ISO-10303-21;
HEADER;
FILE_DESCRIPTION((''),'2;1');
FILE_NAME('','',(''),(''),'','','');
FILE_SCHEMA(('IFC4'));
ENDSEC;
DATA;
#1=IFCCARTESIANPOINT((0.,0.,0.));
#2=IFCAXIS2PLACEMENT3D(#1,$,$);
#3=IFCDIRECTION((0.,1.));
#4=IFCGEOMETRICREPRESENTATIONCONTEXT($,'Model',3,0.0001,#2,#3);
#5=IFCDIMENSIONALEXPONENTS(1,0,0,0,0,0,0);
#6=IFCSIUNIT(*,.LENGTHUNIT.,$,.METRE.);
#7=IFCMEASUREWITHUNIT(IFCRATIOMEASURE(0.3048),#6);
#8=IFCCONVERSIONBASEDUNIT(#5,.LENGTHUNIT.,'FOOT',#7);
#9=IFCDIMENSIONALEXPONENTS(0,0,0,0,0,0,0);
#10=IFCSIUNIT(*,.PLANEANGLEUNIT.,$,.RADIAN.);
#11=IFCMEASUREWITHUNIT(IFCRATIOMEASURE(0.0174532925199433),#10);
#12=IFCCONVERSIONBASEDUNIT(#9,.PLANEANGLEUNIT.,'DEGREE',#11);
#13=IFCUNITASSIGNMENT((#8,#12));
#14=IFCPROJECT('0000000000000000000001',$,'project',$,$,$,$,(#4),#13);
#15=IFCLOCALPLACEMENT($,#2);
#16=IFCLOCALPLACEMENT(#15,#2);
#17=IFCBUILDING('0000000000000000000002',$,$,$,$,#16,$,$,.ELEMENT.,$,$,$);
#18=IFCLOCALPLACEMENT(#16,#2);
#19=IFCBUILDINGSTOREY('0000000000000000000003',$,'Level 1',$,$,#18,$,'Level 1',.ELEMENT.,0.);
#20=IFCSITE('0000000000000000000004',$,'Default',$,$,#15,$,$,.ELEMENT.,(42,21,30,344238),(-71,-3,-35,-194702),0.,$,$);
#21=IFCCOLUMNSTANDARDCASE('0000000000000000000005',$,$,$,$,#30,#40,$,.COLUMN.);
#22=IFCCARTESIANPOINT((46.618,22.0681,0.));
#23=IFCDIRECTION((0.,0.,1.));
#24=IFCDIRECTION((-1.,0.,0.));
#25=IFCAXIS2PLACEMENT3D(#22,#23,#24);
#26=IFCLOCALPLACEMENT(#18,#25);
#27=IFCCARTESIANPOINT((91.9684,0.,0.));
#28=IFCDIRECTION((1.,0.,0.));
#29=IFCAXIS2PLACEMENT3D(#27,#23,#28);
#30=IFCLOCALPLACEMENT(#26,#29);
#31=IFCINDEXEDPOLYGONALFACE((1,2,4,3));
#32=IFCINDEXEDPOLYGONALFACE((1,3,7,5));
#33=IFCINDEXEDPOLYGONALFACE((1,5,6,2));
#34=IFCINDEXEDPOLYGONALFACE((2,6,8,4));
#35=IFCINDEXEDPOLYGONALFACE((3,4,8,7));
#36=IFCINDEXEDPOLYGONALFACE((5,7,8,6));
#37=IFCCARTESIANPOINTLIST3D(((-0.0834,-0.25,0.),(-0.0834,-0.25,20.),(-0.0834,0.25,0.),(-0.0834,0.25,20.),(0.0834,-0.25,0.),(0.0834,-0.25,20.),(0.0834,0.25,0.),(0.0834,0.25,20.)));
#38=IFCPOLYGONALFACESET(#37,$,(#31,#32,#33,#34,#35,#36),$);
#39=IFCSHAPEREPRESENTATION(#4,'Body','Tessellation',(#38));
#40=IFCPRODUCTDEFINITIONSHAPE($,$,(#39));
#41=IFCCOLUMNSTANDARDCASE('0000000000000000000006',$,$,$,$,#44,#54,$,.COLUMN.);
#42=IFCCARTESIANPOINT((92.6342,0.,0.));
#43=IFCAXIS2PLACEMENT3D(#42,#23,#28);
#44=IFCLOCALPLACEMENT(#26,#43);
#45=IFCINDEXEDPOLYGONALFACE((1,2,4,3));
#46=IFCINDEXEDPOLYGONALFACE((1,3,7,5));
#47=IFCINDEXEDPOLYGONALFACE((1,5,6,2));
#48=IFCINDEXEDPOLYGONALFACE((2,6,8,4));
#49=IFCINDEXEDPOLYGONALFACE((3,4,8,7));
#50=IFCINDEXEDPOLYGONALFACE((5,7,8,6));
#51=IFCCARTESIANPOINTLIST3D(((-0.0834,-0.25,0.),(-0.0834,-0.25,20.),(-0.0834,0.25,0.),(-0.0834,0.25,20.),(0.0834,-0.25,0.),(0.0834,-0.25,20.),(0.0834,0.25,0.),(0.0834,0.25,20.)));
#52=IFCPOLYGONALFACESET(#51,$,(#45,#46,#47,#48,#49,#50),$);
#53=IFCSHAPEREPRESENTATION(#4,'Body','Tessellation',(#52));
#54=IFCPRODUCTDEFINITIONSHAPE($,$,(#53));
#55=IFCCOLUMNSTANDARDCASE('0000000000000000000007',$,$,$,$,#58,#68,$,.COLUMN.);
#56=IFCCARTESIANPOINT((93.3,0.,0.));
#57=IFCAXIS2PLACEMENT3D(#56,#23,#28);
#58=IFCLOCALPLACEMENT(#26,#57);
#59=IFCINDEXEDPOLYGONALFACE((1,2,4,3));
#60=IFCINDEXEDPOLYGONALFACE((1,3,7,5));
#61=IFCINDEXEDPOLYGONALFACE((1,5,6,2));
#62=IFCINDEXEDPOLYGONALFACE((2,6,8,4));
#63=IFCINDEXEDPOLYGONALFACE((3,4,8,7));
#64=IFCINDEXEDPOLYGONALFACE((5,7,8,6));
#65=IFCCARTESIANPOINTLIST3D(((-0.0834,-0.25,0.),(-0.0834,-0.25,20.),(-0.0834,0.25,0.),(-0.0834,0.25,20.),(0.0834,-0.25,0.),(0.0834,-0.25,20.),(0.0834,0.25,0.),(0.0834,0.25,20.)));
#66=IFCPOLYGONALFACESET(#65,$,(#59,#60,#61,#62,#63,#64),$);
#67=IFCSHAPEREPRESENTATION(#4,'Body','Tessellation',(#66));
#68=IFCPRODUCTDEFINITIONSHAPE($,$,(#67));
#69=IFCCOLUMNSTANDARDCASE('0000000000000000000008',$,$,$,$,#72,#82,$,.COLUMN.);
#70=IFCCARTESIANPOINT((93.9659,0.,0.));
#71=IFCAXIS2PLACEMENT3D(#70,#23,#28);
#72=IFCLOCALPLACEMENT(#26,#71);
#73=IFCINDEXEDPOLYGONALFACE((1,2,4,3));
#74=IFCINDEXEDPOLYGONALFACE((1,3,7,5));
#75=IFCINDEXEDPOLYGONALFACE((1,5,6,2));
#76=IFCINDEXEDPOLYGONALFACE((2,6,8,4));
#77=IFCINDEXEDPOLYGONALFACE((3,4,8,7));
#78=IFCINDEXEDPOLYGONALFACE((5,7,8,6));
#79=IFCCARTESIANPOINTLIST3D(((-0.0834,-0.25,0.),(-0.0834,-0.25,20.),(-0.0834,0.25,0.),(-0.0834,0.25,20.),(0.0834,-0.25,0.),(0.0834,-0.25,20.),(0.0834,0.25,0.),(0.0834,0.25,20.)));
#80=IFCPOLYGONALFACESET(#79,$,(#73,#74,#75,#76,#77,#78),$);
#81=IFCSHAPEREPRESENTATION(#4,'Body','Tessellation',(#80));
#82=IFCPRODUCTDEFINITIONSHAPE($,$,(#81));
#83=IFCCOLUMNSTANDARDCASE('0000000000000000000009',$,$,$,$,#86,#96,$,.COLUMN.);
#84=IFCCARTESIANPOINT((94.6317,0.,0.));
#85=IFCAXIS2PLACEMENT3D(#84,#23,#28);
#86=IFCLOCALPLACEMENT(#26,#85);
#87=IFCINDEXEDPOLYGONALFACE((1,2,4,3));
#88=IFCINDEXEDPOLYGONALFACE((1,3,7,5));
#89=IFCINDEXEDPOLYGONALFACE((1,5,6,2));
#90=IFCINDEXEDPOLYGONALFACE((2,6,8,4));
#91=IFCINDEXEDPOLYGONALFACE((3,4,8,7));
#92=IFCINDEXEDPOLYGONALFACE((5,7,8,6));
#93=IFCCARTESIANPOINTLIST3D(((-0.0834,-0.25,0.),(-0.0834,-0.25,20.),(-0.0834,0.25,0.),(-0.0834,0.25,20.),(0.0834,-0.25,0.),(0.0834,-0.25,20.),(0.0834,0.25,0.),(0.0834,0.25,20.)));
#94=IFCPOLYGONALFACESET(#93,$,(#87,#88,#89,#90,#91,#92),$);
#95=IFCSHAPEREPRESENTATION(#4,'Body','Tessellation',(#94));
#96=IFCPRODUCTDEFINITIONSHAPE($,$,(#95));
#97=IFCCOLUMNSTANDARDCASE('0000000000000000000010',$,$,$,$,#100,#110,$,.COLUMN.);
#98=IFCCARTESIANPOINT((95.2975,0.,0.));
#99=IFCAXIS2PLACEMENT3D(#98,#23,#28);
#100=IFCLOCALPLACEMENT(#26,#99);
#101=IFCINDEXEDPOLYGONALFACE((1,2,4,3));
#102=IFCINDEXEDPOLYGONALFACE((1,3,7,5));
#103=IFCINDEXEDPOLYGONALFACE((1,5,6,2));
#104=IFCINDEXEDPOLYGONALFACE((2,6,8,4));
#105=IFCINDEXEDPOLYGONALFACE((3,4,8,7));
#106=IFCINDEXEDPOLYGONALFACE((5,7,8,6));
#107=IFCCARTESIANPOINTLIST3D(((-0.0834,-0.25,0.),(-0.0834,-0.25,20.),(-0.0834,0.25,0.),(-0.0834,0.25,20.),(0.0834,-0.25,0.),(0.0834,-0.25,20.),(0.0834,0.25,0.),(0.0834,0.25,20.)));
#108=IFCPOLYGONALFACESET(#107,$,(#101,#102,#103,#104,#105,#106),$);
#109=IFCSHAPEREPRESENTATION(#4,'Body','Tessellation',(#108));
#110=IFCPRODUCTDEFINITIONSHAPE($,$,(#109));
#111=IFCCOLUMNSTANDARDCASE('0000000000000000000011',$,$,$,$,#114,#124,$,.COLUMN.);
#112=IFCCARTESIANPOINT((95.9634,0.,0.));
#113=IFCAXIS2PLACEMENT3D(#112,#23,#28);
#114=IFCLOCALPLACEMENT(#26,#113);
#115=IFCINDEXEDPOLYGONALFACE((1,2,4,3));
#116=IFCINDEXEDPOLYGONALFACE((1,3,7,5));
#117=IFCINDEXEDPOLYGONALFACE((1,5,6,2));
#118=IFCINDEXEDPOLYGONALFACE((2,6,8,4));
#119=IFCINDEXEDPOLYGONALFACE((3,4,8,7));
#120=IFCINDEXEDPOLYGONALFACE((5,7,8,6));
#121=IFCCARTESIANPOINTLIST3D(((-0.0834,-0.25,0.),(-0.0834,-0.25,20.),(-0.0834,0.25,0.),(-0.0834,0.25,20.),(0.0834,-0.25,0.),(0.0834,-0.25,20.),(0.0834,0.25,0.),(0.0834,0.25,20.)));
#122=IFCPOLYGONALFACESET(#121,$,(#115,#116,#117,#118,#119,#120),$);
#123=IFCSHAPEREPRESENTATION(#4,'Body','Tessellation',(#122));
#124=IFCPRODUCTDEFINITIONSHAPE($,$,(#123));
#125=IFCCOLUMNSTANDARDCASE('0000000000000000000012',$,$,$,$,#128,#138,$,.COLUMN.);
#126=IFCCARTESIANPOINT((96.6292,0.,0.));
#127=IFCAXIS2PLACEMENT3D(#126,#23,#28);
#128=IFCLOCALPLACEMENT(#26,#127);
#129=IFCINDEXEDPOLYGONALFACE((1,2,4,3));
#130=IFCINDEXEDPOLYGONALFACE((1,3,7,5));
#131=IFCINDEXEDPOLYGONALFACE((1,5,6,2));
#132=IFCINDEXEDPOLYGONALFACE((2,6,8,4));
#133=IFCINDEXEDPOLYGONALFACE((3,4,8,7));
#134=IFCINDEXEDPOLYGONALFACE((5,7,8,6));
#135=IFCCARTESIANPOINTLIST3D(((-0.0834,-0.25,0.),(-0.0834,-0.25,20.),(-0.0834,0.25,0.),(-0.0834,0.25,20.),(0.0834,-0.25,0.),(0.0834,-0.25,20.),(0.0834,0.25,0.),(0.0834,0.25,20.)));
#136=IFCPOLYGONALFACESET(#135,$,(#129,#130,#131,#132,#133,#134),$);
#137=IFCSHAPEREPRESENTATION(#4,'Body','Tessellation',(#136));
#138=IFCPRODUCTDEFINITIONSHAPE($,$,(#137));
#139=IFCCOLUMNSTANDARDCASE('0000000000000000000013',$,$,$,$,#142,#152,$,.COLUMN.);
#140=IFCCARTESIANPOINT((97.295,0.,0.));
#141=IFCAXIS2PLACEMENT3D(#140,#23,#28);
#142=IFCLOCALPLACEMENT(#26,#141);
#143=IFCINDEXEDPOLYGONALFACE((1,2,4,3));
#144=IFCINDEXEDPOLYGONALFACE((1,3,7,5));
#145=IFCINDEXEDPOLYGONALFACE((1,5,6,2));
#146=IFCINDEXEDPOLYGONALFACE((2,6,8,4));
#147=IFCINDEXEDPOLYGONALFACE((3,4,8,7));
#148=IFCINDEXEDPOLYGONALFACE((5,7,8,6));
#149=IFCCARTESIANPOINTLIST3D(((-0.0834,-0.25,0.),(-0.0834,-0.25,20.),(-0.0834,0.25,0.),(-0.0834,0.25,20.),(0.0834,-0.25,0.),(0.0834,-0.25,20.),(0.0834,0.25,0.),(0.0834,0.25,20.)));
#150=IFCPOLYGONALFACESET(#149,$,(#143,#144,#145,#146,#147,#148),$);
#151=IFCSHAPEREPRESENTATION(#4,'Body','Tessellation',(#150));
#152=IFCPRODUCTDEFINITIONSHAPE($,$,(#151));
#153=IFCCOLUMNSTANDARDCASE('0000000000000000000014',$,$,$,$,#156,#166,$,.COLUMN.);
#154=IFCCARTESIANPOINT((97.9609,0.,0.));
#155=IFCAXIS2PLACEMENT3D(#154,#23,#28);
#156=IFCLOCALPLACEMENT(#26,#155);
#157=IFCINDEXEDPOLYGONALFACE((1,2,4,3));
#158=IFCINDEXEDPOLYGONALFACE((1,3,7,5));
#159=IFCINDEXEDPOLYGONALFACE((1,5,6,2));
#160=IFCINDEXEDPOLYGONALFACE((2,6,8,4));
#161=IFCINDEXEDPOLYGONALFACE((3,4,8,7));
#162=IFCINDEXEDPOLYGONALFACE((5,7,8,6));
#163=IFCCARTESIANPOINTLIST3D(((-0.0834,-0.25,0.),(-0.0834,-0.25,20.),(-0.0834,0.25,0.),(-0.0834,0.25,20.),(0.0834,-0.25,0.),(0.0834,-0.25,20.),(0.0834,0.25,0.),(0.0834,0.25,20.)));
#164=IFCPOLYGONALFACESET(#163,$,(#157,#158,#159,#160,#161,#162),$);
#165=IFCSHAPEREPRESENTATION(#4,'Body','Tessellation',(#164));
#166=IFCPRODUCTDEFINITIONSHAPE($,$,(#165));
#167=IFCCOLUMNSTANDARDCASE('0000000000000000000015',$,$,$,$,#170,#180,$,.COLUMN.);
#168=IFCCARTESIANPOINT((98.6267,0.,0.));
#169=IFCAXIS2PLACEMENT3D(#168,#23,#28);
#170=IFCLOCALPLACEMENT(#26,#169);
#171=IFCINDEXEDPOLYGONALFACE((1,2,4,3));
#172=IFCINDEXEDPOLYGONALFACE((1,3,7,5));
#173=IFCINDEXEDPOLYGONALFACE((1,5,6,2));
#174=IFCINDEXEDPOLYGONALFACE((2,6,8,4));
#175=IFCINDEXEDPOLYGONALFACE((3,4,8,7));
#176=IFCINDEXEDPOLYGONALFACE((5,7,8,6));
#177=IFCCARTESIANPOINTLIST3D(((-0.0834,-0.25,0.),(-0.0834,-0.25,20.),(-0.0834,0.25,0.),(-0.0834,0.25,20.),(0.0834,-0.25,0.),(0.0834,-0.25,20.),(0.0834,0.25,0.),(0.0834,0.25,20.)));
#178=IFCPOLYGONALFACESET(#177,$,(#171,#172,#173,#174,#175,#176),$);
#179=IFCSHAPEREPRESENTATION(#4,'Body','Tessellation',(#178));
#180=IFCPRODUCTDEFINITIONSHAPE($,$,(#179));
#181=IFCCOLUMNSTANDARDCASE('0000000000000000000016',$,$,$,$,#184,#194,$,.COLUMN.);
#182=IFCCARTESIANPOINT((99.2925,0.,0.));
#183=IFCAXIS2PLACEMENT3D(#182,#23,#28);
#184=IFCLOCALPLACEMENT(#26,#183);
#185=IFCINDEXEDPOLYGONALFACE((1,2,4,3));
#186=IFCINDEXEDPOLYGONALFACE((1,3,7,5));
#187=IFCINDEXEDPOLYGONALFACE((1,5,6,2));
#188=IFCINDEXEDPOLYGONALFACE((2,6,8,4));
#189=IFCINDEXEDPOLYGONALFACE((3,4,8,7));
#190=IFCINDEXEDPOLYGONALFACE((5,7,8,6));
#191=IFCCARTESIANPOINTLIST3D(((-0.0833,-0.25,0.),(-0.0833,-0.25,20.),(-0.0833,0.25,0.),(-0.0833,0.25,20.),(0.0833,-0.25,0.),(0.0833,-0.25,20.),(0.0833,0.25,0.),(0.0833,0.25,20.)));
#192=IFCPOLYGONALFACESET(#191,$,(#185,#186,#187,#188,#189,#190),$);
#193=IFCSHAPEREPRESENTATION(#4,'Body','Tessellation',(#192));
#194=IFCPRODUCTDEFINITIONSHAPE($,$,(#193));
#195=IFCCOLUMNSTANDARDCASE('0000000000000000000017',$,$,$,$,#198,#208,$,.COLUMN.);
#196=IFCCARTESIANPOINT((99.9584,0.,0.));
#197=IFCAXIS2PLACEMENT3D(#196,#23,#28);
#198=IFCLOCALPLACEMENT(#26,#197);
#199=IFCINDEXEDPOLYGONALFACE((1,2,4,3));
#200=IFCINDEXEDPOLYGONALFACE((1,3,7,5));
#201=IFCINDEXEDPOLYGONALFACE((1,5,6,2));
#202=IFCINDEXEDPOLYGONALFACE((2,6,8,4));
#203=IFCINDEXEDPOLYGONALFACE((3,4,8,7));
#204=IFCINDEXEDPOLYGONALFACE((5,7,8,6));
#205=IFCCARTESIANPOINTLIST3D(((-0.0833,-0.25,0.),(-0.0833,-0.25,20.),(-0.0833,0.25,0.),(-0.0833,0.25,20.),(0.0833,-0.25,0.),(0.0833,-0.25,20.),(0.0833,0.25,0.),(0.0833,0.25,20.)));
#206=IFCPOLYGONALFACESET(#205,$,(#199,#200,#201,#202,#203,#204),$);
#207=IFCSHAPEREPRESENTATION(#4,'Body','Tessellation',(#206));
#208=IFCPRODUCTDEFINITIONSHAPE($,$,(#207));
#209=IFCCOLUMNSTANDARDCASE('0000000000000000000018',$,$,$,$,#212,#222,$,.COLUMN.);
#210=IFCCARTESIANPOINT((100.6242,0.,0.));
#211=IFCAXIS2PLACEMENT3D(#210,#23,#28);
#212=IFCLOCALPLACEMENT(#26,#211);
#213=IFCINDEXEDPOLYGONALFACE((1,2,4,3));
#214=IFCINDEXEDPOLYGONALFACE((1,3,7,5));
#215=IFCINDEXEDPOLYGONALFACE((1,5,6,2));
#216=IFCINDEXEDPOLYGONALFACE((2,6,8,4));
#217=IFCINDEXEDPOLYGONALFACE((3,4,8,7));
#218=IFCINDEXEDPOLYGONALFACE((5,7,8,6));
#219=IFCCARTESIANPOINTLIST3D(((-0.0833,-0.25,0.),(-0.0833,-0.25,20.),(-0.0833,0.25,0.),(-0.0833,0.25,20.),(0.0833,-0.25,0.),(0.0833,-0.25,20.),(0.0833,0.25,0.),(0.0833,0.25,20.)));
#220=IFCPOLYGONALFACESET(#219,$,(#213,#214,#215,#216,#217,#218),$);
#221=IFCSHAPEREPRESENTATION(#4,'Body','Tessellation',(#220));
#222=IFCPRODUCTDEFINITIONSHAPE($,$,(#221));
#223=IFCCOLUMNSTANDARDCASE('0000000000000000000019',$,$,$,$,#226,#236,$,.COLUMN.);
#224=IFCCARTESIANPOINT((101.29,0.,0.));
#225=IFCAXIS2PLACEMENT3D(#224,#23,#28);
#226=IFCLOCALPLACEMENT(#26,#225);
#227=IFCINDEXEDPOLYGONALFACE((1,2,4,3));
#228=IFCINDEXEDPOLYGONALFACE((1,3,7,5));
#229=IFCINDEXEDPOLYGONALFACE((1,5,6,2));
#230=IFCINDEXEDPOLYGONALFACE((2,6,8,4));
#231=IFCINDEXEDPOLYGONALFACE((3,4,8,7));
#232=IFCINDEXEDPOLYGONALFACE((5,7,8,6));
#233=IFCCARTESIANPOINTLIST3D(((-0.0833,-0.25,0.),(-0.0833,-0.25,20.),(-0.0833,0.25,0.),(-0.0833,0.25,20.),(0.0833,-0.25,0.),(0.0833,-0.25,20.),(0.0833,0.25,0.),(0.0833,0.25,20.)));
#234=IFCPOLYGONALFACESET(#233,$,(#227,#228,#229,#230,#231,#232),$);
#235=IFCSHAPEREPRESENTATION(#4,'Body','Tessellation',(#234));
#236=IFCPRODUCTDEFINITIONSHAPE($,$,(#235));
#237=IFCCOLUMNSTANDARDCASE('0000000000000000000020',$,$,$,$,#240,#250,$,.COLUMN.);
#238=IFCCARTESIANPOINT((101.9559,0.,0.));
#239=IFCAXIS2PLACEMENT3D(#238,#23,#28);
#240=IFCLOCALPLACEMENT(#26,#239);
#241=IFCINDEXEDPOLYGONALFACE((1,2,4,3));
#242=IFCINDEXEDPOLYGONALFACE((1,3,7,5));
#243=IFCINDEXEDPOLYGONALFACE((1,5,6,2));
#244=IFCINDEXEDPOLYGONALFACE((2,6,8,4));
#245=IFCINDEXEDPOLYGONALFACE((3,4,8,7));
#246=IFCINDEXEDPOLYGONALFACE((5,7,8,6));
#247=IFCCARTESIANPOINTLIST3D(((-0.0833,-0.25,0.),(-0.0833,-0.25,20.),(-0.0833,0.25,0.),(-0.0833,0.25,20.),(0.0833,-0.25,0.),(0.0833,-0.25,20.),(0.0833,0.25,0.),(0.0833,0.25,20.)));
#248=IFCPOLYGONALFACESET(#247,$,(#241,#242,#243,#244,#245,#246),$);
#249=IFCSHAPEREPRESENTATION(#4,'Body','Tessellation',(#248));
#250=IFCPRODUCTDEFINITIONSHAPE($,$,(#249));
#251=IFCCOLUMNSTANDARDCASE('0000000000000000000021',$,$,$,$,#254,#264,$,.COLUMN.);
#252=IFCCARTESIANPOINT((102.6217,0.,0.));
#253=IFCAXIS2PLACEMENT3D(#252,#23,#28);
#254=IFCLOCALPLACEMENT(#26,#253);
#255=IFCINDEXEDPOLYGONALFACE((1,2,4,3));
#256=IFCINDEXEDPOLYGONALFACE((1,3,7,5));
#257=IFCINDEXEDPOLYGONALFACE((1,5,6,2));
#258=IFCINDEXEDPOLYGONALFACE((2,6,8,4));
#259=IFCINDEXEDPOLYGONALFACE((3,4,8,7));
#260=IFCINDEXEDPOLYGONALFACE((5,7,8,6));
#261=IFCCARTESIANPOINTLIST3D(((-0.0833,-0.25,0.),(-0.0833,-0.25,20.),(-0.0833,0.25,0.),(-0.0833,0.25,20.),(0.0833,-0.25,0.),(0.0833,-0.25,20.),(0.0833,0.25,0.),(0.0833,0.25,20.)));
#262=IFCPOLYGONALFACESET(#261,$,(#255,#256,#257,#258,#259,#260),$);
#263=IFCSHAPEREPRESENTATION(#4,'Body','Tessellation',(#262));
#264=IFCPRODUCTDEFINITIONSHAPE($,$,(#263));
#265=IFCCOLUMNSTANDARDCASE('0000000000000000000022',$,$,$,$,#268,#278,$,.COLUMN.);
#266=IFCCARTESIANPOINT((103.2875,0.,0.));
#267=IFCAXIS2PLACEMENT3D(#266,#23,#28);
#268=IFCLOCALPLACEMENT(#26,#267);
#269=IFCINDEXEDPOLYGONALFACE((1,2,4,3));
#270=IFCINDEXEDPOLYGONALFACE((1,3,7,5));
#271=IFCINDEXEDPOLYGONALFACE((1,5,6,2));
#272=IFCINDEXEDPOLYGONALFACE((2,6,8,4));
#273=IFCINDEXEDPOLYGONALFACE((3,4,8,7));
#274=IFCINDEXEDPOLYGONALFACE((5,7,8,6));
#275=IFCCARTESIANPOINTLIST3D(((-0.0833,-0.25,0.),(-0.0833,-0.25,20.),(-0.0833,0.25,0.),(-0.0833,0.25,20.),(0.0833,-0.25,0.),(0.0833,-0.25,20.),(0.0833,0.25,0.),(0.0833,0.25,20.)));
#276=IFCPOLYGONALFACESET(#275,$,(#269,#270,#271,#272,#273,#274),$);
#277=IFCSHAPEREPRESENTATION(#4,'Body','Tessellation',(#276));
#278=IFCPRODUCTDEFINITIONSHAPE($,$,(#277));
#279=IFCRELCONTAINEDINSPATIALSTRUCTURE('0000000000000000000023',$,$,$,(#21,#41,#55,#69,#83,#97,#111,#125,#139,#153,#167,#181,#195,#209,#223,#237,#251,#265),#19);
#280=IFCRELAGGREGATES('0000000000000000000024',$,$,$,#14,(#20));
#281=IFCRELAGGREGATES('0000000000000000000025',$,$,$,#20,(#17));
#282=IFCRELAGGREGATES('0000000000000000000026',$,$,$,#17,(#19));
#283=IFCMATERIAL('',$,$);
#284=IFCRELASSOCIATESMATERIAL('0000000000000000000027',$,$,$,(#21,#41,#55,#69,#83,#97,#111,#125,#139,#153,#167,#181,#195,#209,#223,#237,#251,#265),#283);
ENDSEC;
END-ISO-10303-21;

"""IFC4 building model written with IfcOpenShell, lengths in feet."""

from ifc_helpers import new_model, entity, si_unit, converted_unit, direction, frame, origin, place, context, project, spatial, rectangle, extrude, material, element, save


model = new_model("IFC4")

# Units and contexts
model_context = context("Model", 3, precision=0.0001, world=origin(), true_north=direction((0.0, 1.0)))
ifc_project = project(units=[converted_unit("LENGTHUNIT", "FOOT", entity("IfcRatioMeasure", 0.3048), si_unit("LENGTHUNIT", "METRE"), dimensions=[1, 0, 0, 0, 0, 0, 0]), converted_unit("PLANEANGLEUNIT", "DEGREE", entity("IfcRatioMeasure", 0.0174532925199433), si_unit("PLANEANGLEUNIT", "RADIAN"), dimensions=[0, 0, 0, 0, 0, 0, 0])], contexts=[model_context])

# Site, building, storey
site_placement = place(None, origin())
site = spatial("IfcSite", under=ifc_project, at=site_placement, Name="Default", CompositionType="ELEMENT", RefLatitude=(42, 21, 30, 344238), RefLongitude=(-71, -3, -35, -194702), RefElevation=0.0)
building_placement = place(site_placement, origin())
building = spatial("IfcBuilding", under=site, at=building_placement, CompositionType="ELEMENT")
storey_placement = place(building_placement, origin())
storey = spatial("IfcBuildingStorey", under=building, at=storey_placement, Name="Level 1", LongName="Level 1", CompositionType="ELEMENT", Elevation=0.0)

# Columns
ifc_material = material(Name="")
placement_1 = place(storey_placement, frame((46.618, 22.0681, 0.0), z_axis=(0.0, 0.0, 1.0), x_axis=(-1.0, 0.0, 0.0)))
for number, where, z_axis, x_axis in (
    (1, (91.9684, 0.0, 0.0), (0.0, 0.0, 1.0), (1.0, 0.0, 0.0)),
    (2, (92.6342, 0.0, 0.0), (0.0, 0.0, 1.0), (1.0, 0.0, 0.0)),
    (3, (93.3, 0.0, 0.0), (0.0, 0.0, 1.0), (1.0, 0.0, 0.0)),
    (4, (93.9659, 0.0, 0.0), (0.0, 0.0, 1.0), (1.0, 0.0, 0.0)),
    (5, (94.6317, 0.0, 0.0), (0.0, 0.0, 1.0), (1.0, 0.0, 0.0)),
    (6, (95.2975, 0.0, 0.0), (0.0, 0.0, 1.0), (1.0, 0.0, 0.0)),
    (7, (95.9634, 0.0, 0.0), (0.0, 0.0, 1.0), (1.0, 0.0, 0.0)),
    (8, (96.6292, 0.0, 0.0), (0.0, 0.0, 1.0), (1.0, 0.0, 0.0)),
    (9, (97.295, 0.0, 0.0), (0.0, 0.0, 1.0), (1.0, 0.0, 0.0)),
    (10, (97.9609, 0.0, 0.0), (0.0, 0.0, 1.0), (1.0, 0.0, 0.0)),
    (11, (98.6267, 0.0, 0.0), (0.0, 0.0, 1.0), (1.0, 0.0, 0.0)),
    (12, (99.2925, 0.0, 0.0), (0.0, 0.0, 1.0), (1.0, 0.0, 0.0)),
    (13, (99.9584, 0.0, 0.0), (0.0, 0.0, 1.0), (1.0, 0.0, 0.0)),
    (14, (100.6242, 0.0, 0.0), (0.0, 0.0, 1.0), (1.0, 0.0, 0.0)),
    (15, (101.29, 0.0, 0.0), (0.0, 0.0, 1.0), (1.0, 0.0, 0.0)),
    (16, (101.9559, 0.0, 0.0), (0.0, 0.0, 1.0), (1.0, 0.0, 0.0)),
    (17, (102.6217, 0.0, 0.0), (0.0, 0.0, 1.0), (1.0, 0.0, 0.0)),
    (18, (103.2875, 0.0, 0.0), (0.0, 0.0, 1.0), (1.0, 0.0, 0.0)),
):
    element("IfcColumnStandardCase", number, at=place(placement_1, frame(where, z_axis=z_axis, x_axis=x_axis)), inside=storey, material=ifc_material, PredefinedType="COLUMN", context=model_context, shape_type="SweptSolid", body=[
        extrude(rectangle(XDim=0.1667, YDim=0.5), origin(), (0.0, 0.0, 1.0), 20.0),
    ])

save(model, "model.ifc")
